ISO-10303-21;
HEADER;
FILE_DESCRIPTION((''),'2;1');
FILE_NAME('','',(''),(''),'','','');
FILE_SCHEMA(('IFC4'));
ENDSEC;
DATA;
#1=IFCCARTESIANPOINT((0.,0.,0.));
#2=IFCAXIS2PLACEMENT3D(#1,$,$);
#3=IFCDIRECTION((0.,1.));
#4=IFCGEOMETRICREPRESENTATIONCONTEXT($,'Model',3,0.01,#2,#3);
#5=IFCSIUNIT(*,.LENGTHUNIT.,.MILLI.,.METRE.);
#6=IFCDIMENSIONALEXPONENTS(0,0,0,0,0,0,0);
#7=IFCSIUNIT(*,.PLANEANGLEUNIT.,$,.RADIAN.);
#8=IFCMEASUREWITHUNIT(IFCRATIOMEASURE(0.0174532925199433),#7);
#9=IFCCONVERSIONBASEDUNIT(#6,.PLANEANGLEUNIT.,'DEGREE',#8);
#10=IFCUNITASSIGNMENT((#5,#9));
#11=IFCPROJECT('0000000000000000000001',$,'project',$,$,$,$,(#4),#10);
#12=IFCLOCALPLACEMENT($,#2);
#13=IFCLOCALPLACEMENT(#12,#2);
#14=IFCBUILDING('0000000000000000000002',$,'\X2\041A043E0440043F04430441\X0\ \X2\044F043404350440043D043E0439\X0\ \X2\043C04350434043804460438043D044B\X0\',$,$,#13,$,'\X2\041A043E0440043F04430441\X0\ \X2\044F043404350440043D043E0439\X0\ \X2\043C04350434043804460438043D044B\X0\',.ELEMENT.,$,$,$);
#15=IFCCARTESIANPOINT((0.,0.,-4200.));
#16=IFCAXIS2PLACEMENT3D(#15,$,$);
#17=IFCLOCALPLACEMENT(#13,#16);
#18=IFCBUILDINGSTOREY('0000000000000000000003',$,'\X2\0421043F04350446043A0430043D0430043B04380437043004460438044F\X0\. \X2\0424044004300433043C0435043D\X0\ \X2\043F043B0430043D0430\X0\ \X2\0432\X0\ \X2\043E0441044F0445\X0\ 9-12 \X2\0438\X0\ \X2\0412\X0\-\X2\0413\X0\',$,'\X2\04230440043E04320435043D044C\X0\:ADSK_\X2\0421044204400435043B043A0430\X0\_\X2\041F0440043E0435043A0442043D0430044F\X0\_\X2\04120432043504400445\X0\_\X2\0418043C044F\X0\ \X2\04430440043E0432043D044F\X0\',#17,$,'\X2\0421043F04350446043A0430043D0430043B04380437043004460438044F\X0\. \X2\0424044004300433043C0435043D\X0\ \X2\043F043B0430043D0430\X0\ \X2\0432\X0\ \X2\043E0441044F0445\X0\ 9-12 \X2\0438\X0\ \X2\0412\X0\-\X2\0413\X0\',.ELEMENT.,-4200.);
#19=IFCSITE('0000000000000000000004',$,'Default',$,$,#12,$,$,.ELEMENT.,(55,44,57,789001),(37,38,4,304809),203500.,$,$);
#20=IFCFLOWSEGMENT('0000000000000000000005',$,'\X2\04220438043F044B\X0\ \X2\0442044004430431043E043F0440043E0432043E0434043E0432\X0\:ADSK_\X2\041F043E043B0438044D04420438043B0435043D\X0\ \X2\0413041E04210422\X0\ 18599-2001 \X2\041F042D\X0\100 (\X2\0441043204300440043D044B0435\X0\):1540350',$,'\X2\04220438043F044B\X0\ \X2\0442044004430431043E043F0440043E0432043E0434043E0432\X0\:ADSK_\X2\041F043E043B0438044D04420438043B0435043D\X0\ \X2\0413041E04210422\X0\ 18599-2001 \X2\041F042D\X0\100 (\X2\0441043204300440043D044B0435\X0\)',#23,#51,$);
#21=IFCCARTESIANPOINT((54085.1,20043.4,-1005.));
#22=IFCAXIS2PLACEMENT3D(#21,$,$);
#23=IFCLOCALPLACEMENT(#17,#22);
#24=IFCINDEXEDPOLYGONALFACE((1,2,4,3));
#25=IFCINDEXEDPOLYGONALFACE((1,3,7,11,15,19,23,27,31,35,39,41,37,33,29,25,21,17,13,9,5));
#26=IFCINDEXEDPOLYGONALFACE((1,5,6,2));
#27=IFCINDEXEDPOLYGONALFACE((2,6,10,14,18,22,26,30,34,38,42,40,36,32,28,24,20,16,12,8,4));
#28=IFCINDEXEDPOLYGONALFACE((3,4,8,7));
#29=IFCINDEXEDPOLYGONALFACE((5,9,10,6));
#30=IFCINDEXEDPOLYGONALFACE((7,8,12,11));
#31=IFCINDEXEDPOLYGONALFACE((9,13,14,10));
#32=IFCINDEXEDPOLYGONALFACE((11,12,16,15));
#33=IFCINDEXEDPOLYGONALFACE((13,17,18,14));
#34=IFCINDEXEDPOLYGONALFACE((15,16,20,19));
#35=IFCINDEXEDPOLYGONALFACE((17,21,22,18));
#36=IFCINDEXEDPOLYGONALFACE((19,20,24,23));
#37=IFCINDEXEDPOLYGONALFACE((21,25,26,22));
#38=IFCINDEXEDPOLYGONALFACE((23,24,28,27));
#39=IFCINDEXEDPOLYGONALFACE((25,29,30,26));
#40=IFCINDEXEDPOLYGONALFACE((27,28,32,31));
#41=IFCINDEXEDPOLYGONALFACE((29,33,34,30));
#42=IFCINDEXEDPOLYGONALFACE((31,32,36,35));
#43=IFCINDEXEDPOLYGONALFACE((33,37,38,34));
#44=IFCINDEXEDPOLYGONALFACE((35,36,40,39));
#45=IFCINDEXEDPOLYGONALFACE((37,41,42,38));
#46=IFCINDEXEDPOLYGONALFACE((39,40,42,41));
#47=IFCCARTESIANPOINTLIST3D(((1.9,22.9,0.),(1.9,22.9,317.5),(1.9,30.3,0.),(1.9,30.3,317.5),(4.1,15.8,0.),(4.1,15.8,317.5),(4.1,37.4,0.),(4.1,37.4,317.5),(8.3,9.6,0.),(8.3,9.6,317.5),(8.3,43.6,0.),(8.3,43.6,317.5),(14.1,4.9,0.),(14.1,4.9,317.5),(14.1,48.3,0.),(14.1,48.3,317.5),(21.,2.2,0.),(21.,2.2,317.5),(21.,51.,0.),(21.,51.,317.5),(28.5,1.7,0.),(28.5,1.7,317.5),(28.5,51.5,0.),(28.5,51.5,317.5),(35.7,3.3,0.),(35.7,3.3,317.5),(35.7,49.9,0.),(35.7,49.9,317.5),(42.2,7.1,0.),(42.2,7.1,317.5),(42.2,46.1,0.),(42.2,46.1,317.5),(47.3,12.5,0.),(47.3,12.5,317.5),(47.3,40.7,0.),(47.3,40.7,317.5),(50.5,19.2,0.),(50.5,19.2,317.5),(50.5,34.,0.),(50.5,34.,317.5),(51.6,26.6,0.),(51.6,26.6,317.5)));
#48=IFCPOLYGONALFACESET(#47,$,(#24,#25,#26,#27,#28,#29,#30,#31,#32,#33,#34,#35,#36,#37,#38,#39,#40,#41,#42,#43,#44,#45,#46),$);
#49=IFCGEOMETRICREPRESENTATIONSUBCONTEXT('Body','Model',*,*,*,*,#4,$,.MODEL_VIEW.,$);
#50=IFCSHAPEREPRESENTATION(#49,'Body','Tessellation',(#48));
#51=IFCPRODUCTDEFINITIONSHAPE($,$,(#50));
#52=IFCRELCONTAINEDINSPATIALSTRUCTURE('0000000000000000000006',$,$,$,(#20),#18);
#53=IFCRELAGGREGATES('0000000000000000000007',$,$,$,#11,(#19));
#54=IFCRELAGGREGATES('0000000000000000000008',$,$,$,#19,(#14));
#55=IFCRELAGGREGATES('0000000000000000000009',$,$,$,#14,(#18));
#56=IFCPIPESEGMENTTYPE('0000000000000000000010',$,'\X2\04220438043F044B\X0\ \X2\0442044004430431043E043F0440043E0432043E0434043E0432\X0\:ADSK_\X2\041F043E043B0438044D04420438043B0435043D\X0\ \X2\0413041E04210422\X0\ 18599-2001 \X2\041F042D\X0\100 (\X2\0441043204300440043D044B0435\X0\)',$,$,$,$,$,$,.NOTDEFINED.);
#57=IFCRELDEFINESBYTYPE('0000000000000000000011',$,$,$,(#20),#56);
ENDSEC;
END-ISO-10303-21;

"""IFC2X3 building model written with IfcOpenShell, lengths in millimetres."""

from ifc_helpers import new_model, entity, si_unit, converted_unit, direction, frame, origin, origin_2d_with_axis, place, context, subcontext, project, spatial, circle, extrude, type_object, element, save


model = new_model("IFC2X3")

# Units and contexts
model_context = context("Model", 3, precision=0.01, world=origin(), true_north=direction((0.0, 1.0)))
body_context = subcontext(model_context, "Body", "Model", "MODEL_VIEW")
ifc_project = project(units=[si_unit("LENGTHUNIT", "METRE", prefix="MILLI"), converted_unit("PLANEANGLEUNIT", "DEGREE", entity("IfcRatioMeasure", 0.0174532925199433), si_unit("PLANEANGLEUNIT", "RADIAN"), dimensions=[0, 0, 0, 0, 0, 0, 0])], contexts=[model_context])

# Site, building, storey
site_placement = place(None, origin())
site = spatial("IfcSite", under=ifc_project, at=site_placement, Name="Default", CompositionType="ELEMENT", RefLatitude=(55, 44, 57, 789001), RefLongitude=(37, 38, 4, 304809), RefElevation=203500.0)
building_placement = place(site_placement, origin())
building = spatial("IfcBuilding", under=site, at=building_placement, Name="Корпус ядерной медицины", LongName="Корпус ядерной медицины", CompositionType="ELEMENT")
storey_placement = place(building_placement, frame((0.0, 0.0, -4200.0)))
storey = spatial("IfcBuildingStorey", under=building, at=storey_placement, Name="Спецканализация. Фрагмен плана в осях 9-12 и В-Г", ObjectType="Уровень:ADSK_Стрелка_Проектная_Вверх_Имя уровня", LongName="Спецканализация. Фрагмен плана в осях 9-12 и В-Г", CompositionType="ELEMENT", Elevation=-4200.0)

# Flow segment
pipe_segment_type = type_object("IfcPipeSegmentType", Name="Типы трубопроводов:ADSK_Полиэтилен ГОСТ 18599-2001 ПЭ100 (сварные)", PredefinedType="NOTDEFINED")
flow_segment_1_placement = place(storey_placement, frame((54085.1, 20043.4, -1005.0)))
element("IfcFlowSegment", 1, at=flow_segment_1_placement, inside=storey, type_object=pipe_segment_type, Name="Типы трубопроводов:ADSK_Полиэтилен ГОСТ 18599-2001 ПЭ100 (сварные):1540350", ObjectType="Типы трубопроводов:ADSK_Полиэтилен ГОСТ 18599-2001 ПЭ100 (сварные)", context=body_context, shape_type="SweptSolid", body=[
    extrude(circle(Radius=25.0, at=origin_2d_with_axis()), frame((26.6, 26.6, 0.0)), (0.0, 0.0, 1.0), 317.5),
])

save(model, "model.ifc")
